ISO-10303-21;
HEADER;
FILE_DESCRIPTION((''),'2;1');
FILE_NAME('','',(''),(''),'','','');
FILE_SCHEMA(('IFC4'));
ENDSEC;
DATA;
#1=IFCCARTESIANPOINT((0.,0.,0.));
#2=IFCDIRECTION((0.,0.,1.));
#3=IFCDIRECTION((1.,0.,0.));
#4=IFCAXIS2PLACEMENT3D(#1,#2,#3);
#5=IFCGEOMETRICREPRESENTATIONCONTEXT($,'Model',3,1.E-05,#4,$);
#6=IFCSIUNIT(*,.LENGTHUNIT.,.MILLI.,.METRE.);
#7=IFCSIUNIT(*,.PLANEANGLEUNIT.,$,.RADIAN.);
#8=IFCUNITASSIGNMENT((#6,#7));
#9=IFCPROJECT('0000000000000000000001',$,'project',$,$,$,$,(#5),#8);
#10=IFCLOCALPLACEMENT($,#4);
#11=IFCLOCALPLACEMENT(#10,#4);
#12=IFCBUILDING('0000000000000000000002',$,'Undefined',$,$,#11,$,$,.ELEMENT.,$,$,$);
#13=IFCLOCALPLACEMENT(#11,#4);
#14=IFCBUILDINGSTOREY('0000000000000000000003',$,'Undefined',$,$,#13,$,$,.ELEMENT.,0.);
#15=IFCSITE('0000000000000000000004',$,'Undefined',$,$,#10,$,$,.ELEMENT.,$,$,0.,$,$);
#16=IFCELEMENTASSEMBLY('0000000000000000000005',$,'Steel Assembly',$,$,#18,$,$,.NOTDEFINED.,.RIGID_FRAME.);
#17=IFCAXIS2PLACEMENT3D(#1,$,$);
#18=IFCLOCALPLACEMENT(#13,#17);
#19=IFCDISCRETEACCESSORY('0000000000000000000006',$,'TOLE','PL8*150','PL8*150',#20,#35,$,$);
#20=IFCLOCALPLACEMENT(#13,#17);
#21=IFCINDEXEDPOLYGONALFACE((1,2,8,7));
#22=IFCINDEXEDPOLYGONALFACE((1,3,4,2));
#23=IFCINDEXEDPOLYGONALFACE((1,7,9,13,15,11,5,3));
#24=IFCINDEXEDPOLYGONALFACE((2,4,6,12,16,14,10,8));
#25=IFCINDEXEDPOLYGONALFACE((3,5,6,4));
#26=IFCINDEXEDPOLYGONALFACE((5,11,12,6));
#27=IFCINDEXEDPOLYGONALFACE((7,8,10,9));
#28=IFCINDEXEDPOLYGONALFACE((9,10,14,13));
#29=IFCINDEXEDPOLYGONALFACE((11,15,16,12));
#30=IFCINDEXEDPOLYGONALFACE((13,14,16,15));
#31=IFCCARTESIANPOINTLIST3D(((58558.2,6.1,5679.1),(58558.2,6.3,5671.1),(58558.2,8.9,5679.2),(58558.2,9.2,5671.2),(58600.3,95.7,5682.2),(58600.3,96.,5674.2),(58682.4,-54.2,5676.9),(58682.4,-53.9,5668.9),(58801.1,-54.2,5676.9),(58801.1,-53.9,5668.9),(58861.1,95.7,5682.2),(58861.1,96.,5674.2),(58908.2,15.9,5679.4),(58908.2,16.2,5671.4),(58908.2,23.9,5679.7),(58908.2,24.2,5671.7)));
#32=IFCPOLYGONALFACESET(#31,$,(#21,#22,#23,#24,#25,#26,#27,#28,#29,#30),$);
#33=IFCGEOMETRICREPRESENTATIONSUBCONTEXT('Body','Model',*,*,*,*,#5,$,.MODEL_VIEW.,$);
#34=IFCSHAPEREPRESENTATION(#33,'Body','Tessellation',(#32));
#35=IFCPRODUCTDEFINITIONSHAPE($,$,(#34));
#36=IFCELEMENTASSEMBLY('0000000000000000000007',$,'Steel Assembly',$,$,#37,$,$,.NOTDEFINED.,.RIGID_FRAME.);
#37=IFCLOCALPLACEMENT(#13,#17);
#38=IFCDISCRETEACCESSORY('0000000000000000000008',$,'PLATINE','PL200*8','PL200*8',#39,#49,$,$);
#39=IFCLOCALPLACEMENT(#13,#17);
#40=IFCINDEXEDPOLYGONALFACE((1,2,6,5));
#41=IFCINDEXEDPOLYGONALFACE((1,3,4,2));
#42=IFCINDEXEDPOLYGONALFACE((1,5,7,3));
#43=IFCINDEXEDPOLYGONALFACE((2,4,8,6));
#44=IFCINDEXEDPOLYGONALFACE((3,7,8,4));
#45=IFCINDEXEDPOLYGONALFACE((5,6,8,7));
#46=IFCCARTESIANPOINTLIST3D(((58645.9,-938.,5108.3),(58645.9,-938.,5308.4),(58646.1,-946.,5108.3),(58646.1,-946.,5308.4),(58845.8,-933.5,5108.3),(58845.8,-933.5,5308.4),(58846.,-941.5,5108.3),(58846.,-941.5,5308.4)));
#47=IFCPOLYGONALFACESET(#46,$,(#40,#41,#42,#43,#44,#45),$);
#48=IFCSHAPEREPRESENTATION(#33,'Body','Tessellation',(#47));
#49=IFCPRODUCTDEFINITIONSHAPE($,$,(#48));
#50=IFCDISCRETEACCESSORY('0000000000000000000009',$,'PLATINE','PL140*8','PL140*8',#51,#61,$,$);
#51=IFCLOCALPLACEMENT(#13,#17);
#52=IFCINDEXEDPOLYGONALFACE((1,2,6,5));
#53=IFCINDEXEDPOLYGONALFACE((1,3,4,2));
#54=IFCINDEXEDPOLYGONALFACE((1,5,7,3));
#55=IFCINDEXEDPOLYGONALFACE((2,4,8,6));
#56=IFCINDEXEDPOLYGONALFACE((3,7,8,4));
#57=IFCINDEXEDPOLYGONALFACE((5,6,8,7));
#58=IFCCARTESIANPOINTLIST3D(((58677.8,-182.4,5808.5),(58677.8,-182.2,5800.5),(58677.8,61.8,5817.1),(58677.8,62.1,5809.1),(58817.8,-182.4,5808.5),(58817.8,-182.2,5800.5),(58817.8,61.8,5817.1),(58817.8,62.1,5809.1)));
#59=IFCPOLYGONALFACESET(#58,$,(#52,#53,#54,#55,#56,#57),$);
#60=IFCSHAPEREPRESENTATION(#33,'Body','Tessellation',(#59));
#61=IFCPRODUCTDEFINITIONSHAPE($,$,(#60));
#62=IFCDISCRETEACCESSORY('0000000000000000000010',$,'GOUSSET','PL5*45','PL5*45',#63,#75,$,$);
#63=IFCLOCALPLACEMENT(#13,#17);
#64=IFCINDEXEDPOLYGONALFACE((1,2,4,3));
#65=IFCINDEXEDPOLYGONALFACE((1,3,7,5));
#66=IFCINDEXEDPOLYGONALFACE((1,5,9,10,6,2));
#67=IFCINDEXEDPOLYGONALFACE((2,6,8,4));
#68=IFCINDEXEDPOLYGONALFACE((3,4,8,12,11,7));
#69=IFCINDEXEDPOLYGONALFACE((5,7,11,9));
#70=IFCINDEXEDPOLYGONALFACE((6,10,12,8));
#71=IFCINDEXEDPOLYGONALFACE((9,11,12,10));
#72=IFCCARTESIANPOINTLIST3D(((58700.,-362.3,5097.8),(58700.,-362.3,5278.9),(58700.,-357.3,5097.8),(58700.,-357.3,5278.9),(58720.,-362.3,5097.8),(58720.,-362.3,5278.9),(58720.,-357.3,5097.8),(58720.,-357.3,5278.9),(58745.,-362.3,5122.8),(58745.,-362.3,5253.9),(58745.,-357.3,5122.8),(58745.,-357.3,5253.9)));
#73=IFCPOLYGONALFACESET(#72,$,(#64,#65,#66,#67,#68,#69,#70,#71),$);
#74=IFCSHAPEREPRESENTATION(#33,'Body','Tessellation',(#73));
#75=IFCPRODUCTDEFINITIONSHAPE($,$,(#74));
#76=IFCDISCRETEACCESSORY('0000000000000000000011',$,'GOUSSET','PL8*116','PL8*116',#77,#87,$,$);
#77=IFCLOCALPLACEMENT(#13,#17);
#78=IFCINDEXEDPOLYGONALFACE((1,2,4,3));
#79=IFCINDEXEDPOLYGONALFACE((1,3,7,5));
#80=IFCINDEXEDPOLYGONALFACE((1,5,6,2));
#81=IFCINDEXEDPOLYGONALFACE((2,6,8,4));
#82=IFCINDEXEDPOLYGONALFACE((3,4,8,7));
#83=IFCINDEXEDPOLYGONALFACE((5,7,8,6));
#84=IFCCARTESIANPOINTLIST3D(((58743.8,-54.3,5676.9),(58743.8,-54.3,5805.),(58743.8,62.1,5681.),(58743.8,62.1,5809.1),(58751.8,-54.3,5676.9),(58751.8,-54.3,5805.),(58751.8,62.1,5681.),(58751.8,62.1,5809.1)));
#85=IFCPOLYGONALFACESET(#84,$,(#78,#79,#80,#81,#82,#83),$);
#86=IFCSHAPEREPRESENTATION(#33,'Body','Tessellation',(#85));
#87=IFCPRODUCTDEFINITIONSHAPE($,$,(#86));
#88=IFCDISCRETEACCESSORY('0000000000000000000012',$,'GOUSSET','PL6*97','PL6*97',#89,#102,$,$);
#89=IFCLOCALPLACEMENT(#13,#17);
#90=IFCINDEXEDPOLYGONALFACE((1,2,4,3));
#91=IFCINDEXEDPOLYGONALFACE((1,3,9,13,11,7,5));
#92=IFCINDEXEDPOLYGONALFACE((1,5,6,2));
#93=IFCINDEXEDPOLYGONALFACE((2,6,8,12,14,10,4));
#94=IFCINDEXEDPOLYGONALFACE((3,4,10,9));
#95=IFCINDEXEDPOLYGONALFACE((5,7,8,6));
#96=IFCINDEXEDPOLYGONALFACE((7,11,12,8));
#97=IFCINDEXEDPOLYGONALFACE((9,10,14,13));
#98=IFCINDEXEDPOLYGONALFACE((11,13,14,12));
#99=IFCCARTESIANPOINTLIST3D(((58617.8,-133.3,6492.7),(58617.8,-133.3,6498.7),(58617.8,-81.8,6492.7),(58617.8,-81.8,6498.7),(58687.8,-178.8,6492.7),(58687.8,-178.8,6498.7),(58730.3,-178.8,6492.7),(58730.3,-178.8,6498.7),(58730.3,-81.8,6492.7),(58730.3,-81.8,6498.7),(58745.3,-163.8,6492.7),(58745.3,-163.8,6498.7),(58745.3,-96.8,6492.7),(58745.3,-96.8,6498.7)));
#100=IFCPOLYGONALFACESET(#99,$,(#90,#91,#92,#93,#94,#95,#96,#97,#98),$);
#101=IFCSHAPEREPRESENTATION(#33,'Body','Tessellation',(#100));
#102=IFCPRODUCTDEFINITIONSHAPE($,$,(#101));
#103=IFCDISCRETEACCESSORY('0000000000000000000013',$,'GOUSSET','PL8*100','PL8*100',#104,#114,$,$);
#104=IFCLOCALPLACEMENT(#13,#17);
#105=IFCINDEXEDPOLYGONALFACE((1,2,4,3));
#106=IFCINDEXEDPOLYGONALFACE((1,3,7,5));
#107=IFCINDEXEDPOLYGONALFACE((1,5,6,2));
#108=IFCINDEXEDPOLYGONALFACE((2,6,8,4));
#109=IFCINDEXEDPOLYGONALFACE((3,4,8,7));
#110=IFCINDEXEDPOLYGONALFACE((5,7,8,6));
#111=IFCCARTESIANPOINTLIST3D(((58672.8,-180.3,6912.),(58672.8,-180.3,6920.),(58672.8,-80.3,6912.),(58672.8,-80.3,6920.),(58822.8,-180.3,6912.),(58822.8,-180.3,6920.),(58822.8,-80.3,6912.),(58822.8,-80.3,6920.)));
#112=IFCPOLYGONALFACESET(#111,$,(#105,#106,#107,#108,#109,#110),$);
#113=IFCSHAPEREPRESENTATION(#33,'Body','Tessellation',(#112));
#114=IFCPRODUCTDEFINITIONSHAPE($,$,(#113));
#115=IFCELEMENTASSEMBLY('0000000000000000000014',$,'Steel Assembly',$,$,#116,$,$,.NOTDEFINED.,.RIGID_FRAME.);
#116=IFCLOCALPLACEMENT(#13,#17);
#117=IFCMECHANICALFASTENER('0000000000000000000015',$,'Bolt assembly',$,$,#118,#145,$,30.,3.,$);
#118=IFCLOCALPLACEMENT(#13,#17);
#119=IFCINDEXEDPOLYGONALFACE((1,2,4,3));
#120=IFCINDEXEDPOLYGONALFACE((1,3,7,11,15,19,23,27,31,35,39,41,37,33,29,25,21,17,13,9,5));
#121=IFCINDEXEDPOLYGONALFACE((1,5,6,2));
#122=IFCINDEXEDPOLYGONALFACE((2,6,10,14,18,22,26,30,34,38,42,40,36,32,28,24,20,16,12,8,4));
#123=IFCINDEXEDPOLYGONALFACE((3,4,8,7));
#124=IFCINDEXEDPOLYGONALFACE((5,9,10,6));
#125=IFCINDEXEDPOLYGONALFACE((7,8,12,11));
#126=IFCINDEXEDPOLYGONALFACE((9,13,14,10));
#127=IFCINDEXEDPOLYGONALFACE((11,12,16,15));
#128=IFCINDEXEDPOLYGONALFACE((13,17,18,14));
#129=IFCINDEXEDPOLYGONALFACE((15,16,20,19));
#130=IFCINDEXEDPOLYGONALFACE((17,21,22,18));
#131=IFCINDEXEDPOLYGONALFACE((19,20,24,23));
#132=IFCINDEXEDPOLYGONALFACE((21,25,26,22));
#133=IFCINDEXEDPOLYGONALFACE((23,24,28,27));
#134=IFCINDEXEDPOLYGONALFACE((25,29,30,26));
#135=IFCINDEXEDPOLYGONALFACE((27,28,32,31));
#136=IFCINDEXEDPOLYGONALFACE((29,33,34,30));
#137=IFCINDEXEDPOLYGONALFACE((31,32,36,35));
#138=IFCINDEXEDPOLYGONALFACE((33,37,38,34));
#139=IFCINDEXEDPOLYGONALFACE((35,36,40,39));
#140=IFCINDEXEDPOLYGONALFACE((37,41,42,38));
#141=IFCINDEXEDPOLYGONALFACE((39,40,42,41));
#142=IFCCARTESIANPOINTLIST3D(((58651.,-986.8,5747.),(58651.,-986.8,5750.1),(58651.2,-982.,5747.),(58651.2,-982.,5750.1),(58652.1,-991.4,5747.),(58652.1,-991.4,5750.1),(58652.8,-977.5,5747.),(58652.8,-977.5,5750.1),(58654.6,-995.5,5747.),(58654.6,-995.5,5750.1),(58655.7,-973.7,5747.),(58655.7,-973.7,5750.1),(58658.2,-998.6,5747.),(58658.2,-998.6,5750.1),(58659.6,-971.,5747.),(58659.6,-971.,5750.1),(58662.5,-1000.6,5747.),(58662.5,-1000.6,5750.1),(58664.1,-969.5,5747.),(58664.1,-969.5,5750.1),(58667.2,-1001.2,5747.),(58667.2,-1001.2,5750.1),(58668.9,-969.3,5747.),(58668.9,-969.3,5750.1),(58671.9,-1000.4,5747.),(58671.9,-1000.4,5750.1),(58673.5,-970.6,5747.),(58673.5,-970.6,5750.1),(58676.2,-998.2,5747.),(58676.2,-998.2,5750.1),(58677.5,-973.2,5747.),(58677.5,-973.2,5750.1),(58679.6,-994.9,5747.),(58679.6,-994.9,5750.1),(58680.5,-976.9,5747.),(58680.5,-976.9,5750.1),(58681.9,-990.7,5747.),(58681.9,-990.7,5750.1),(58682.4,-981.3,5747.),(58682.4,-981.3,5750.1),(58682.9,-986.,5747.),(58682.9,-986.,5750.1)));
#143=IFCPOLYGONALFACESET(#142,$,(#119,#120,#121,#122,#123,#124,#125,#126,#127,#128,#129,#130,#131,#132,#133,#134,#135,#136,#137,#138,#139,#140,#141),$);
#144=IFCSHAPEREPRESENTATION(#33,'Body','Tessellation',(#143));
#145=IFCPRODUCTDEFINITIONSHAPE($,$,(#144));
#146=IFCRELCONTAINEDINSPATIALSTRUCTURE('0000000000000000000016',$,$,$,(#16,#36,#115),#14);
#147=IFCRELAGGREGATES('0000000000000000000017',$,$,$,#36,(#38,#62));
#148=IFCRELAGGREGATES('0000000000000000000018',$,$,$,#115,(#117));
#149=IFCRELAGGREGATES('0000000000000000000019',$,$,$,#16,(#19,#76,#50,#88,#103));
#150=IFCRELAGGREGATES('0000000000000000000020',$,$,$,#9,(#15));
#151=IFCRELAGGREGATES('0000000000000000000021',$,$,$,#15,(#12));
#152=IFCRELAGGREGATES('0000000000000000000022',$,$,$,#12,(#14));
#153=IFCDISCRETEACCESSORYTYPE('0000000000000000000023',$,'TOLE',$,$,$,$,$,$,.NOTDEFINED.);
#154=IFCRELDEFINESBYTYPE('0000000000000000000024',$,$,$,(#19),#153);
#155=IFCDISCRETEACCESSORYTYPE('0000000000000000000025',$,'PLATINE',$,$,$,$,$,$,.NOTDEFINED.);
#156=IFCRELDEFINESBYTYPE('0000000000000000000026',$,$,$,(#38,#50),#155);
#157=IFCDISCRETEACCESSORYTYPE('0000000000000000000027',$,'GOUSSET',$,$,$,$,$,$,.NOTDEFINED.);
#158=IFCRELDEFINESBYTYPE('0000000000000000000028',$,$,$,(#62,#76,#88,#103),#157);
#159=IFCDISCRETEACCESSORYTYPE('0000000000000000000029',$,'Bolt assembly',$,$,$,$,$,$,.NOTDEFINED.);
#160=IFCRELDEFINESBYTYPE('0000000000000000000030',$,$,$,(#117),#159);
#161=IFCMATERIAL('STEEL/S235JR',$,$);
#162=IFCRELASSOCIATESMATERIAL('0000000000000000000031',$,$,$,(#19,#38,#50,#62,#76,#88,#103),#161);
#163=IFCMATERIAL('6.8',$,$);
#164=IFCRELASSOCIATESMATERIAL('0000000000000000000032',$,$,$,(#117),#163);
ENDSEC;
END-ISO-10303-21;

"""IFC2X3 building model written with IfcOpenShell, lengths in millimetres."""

from ifc_helpers import new_model, si_unit, frame, origin_with_axes, origin_2d_with_axis, place, context, subcontext, project, spatial, polyline, circle, outline, extrude, clip, halfspace, source, transform, mapped, material, type_object, element, aggregate, save


model = new_model("IFC2X3")

# Units and contexts
model_context = context("Model", 3, precision=1e-05, world=origin_with_axes())
body_context = subcontext(model_context, "Body", "Model", "MODEL_VIEW")
ifc_project = project(units=[si_unit("LENGTHUNIT", "METRE", prefix="MILLI"), si_unit("PLANEANGLEUNIT", "RADIAN")], contexts=[model_context])

# Site, building, storey
site_placement = place(None, origin_with_axes())
site = spatial("IfcSite", under=ifc_project, at=site_placement, Name="Undefined", CompositionType="ELEMENT", RefElevation=0.0)
building_placement = place(site_placement, origin_with_axes())
building = spatial("IfcBuilding", under=site, at=building_placement, Name="Undefined", CompositionType="ELEMENT")
storey_placement = place(building_placement, origin_with_axes())
storey = spatial("IfcBuildingStorey", under=building, at=storey_placement, Name="Undefined", CompositionType="ELEMENT", Elevation=0.0)

# Shared definitions
ifc_material_1 = material(Name="STEEL/S235JR")

# Shared definitions
discrete_accessory_type_1 = type_object("IfcDiscreteAccessoryType", Name="TOLE")

# Element assemblies, discrete accessories
assembly_1_placement = place(storey_placement, origin_with_axes())
assembly_1 = element("IfcElementAssembly", 1, at=assembly_1_placement, inside=storey, Name="Steel Assembly", AssemblyPlace="NOTDEFINED", PredefinedType="RIGID_FRAME")
discrete_accessory_1_placement = place(assembly_1_placement, frame((58558.2, 20.9, 5675.6), z_axis=(0.0, 0.034979, -0.999388), x_axis=(1.0, 0.0, 0.0)))
discrete_accessory_1 = element("IfcDiscreteAccessory", 2, at=discrete_accessory_1_placement, type_object=discrete_accessory_type_1, material=ifc_material_1, Name="TOLE", Description="PL8*150", ObjectType="PL8*150", context=body_context, shape_type="Clipping", body=[
    clip(clip(clip(clip(extrude(outline(polyline([(350.0, 4.9), (350.0, -3.2), (303.0, -75.0), (42.1, -75.0), (0.0, 11.8), (0.0, 14.7), (124.3, 75.0), (242.9, 75.0), (350.0, 4.9)])), frame((0.0, 0.0, -4.0), z_axis=(0.0, 0.0, 1.0), x_axis=(1.0, 0.0, 0.0)), (0.0, 0.0, 1.0), 8.0), halfspace(frame((-184.9, -75.0, -4.0), z_axis=(-0.436481, 0.899713, 0.0), x_axis=(0.899713, 0.436481, 0.0)), False)), halfspace(frame((472.0, -75.0, 4.0), z_axis=(0.547834, 0.836587, 0.0), x_axis=(-0.836587, 0.547834, 0.0)), False)), halfspace(frame((42.1, -75.0, -4.0), z_axis=(-0.899713, -0.436481, 0.0), x_axis=(-0.436481, 0.899713, 0.0)), False)), halfspace(frame((303.0, -75.0, 4.0), z_axis=(0.836587, -0.547834, 0.0), x_axis=(0.547834, 0.836587, 0.0)), False)),
])
assembly_2_placement = place(storey_placement, origin_with_axes())
assembly_2 = element("IfcElementAssembly", 3, at=assembly_2_placement, inside=storey, Name="Steel Assembly", AssemblyPlace="NOTDEFINED", PredefinedType="RIGID_FRAME")
discrete_accessory_type_2 = type_object("IfcDiscreteAccessoryType", Name="PLATINE")
discrete_accessory_2_placement = place(assembly_2_placement, frame((58746.0, -939.8, 5308.4), z_axis=(-0.022588, 0.999745, 0.000001), x_axis=(-0.000001, 0.000001, -1.0)))
discrete_accessory_2 = element("IfcDiscreteAccessory", 4, at=discrete_accessory_2_placement, type_object=discrete_accessory_type_2, material=ifc_material_1, Name="PLATINE", Description="PL200*8", ObjectType="PL200*8", context=body_context, shape_type="SweptSolid", body=[
    extrude(outline(polyline([(200.1, -100.0), (0.0, -100.0), (0.0, 100.0), (200.1, 100.0), (200.1, -100.0)])), frame((0.0, 0.0, -4.0), z_axis=(0.0, 0.0, 1.0), x_axis=(1.0, 0.0, 0.0)), (0.0, 0.0, 1.0), 8.0),
])

# Discrete accessories
discrete_accessory_3_placement = place(assembly_1_placement, frame((58747.8, -182.3, 5804.5), z_axis=(0.0, -0.034946, 0.999389), x_axis=(0.0, 0.999389, 0.034946)))
discrete_accessory_3 = element("IfcDiscreteAccessory", 5, at=discrete_accessory_3_placement, type_object=discrete_accessory_type_2, material=ifc_material_1, Name="PLATINE", Description="PL140*8", ObjectType="PL140*8", context=body_context, shape_type="SweptSolid", body=[
    extrude(outline(polyline([(244.4, 70.0), (244.4, -70.0), (0.0, -70.0), (0.0, 70.0), (244.4, 70.0)])), frame((0.0, 0.0, -4.0), z_axis=(0.0, 0.0, 1.0), x_axis=(1.0, 0.0, 0.0)), (0.0, 0.0, 1.0), 8.0),
])
discrete_accessory_type_3 = type_object("IfcDiscreteAccessoryType", Name="GOUSSET")
discrete_accessory_4_placement = place(assembly_2_placement, frame((58745.0, -359.8, 5278.9), z_axis=(0.0, -1.0, 0.0), x_axis=(-1.0, 0.0, 0.0)))
discrete_accessory_4 = element("IfcDiscreteAccessory", 6, at=discrete_accessory_4_placement, type_object=discrete_accessory_type_3, material=ifc_material_1, Name="GOUSSET", Description="PL5*45", ObjectType="PL5*45", context=body_context, shape_type="SweptSolid", body=[
    extrude(outline(polyline([(0.0, 25.0), (25.0, 0.0), (45.0, 0.0), (45.0, 181.1), (25.0, 181.1), (0.0, 156.1), (0.0, 25.0)])), frame((0.0, 0.0, -2.5), z_axis=(0.0, 0.0, 1.0), x_axis=(1.0, 0.0, 0.0)), (0.0, 0.0, 1.0), 5.0),
])
aggregate(assembly_2, [discrete_accessory_2, discrete_accessory_4])
discrete_accessory_5_placement = place(assembly_1_placement, frame((58747.8, 62.1, 5809.1), z_axis=(-1.0, 0.0, 0.0), x_axis=(0.0, 0.00003, -1.0)))
discrete_accessory_5 = element("IfcDiscreteAccessory", 7, at=discrete_accessory_5_placement, type_object=discrete_accessory_type_3, material=ifc_material_1, Name="GOUSSET", Description="PL8*116", ObjectType="PL8*116", context=body_context, shape_type="SweptSolid", body=[
    extrude(outline(polyline([(0.0, 0.0), (128.1, 0.0), (132.1, 116.4), (4.1, 116.4), (0.0, 0.0)])), frame((0.0, 0.0, -4.0), z_axis=(0.0, 0.0, 1.0), x_axis=(1.0, 0.0, 0.0)), (0.0, 0.0, 1.0), 8.0),
])
discrete_accessory_6_placement = place(assembly_1_placement, frame((58687.8, -178.8, 6495.7), z_axis=(0.0, 0.0, 1.0), x_axis=(1.0, 0.0, 0.0)))
discrete_accessory_6 = element("IfcDiscreteAccessory", 8, at=discrete_accessory_6_placement, type_object=discrete_accessory_type_3, material=ifc_material_1, Name="GOUSSET", Description="PL6*97", ObjectType="PL6*97", context=body_context, shape_type="SweptSolid", body=[
    extrude(outline(polyline([(0.0, 0.0), (42.5, 0.0), (57.5, 15.0), (57.5, 82.0), (42.5, 97.0), (-70.0, 97.0), (-70.0, 45.5), (0.0, 0.0)])), frame((0.0, 0.0, -3.0), z_axis=(0.0, 0.0, 1.0), x_axis=(1.0, 0.0, 0.0)), (0.0, 0.0, 1.0), 6.0),
])
discrete_accessory_7_placement = place(assembly_1_placement, frame((58672.8, -180.3, 6916.0), z_axis=(0.0, 0.0, 1.0), x_axis=(1.0, 0.0, 0.0)))
discrete_accessory_7 = element("IfcDiscreteAccessory", 9, at=discrete_accessory_7_placement, type_object=discrete_accessory_type_3, material=ifc_material_1, Name="GOUSSET", Description="PL8*100", ObjectType="PL8*100", context=body_context, shape_type="SweptSolid", body=[
    extrude(outline(polyline([(0.0, 0.0), (150.0, 0.0), (150.0, 100.0), (0.0, 100.0), (0.0, 0.0)])), frame((0.0, 0.0, -4.0), z_axis=(0.0, 0.0, 1.0), x_axis=(1.0, 0.0, 0.0)), (0.0, 0.0, 1.0), 8.0),
])

# Element assembly, mechanical fastener
assembly_3_placement = place(storey_placement, origin_with_axes())
assembly_3 = element("IfcElementAssembly", 10, at=assembly_3_placement, inside=storey, Name="Steel Assembly", AssemblyPlace="NOTDEFINED", PredefinedType="RIGID_FRAME")
ifc_material_2 = material(Name="6.8")
discrete_accessory_type_4 = type_object("IfcDiscreteAccessoryType", Name="Bolt assembly")
shared_shape_1 = source(origin_with_axes(), body_context, "Body", "SweptSolid", [
    extrude(circle(Radius=16.0, at=origin_2d_with_axis()), frame((0.0, -0.1, 0.0), z_axis=(0.0, 1.0, 0.0), x_axis=(1.0, 0.0, 0.0)), (0.0, 0.0, 1.0), 3.1),
])
mechanical_fastener_1_placement = place(assembly_3_placement, frame((58666.9, -985.2, 5750.0), z_axis=(0.999745, 0.022588, 0.0), x_axis=(0.022588, -0.999745, 0.000001)))
mechanical_fastener_1 = element("IfcMechanicalFastener", 11, at=mechanical_fastener_1_placement, type_object=discrete_accessory_type_4, material=ifc_material_2, Name="Bolt assembly", NominalDiameter=30.0, NominalLength=3.0, context=body_context, shape_type="MappedRepresentation", body=[
    mapped(shared_shape_1, transform((0.0, 0.0, 0.0))),
])
aggregate(assembly_3, [mechanical_fastener_1])

aggregate(assembly_1, [discrete_accessory_1, discrete_accessory_5, discrete_accessory_3, discrete_accessory_6, discrete_accessory_7])

save(model, "model.ifc")
